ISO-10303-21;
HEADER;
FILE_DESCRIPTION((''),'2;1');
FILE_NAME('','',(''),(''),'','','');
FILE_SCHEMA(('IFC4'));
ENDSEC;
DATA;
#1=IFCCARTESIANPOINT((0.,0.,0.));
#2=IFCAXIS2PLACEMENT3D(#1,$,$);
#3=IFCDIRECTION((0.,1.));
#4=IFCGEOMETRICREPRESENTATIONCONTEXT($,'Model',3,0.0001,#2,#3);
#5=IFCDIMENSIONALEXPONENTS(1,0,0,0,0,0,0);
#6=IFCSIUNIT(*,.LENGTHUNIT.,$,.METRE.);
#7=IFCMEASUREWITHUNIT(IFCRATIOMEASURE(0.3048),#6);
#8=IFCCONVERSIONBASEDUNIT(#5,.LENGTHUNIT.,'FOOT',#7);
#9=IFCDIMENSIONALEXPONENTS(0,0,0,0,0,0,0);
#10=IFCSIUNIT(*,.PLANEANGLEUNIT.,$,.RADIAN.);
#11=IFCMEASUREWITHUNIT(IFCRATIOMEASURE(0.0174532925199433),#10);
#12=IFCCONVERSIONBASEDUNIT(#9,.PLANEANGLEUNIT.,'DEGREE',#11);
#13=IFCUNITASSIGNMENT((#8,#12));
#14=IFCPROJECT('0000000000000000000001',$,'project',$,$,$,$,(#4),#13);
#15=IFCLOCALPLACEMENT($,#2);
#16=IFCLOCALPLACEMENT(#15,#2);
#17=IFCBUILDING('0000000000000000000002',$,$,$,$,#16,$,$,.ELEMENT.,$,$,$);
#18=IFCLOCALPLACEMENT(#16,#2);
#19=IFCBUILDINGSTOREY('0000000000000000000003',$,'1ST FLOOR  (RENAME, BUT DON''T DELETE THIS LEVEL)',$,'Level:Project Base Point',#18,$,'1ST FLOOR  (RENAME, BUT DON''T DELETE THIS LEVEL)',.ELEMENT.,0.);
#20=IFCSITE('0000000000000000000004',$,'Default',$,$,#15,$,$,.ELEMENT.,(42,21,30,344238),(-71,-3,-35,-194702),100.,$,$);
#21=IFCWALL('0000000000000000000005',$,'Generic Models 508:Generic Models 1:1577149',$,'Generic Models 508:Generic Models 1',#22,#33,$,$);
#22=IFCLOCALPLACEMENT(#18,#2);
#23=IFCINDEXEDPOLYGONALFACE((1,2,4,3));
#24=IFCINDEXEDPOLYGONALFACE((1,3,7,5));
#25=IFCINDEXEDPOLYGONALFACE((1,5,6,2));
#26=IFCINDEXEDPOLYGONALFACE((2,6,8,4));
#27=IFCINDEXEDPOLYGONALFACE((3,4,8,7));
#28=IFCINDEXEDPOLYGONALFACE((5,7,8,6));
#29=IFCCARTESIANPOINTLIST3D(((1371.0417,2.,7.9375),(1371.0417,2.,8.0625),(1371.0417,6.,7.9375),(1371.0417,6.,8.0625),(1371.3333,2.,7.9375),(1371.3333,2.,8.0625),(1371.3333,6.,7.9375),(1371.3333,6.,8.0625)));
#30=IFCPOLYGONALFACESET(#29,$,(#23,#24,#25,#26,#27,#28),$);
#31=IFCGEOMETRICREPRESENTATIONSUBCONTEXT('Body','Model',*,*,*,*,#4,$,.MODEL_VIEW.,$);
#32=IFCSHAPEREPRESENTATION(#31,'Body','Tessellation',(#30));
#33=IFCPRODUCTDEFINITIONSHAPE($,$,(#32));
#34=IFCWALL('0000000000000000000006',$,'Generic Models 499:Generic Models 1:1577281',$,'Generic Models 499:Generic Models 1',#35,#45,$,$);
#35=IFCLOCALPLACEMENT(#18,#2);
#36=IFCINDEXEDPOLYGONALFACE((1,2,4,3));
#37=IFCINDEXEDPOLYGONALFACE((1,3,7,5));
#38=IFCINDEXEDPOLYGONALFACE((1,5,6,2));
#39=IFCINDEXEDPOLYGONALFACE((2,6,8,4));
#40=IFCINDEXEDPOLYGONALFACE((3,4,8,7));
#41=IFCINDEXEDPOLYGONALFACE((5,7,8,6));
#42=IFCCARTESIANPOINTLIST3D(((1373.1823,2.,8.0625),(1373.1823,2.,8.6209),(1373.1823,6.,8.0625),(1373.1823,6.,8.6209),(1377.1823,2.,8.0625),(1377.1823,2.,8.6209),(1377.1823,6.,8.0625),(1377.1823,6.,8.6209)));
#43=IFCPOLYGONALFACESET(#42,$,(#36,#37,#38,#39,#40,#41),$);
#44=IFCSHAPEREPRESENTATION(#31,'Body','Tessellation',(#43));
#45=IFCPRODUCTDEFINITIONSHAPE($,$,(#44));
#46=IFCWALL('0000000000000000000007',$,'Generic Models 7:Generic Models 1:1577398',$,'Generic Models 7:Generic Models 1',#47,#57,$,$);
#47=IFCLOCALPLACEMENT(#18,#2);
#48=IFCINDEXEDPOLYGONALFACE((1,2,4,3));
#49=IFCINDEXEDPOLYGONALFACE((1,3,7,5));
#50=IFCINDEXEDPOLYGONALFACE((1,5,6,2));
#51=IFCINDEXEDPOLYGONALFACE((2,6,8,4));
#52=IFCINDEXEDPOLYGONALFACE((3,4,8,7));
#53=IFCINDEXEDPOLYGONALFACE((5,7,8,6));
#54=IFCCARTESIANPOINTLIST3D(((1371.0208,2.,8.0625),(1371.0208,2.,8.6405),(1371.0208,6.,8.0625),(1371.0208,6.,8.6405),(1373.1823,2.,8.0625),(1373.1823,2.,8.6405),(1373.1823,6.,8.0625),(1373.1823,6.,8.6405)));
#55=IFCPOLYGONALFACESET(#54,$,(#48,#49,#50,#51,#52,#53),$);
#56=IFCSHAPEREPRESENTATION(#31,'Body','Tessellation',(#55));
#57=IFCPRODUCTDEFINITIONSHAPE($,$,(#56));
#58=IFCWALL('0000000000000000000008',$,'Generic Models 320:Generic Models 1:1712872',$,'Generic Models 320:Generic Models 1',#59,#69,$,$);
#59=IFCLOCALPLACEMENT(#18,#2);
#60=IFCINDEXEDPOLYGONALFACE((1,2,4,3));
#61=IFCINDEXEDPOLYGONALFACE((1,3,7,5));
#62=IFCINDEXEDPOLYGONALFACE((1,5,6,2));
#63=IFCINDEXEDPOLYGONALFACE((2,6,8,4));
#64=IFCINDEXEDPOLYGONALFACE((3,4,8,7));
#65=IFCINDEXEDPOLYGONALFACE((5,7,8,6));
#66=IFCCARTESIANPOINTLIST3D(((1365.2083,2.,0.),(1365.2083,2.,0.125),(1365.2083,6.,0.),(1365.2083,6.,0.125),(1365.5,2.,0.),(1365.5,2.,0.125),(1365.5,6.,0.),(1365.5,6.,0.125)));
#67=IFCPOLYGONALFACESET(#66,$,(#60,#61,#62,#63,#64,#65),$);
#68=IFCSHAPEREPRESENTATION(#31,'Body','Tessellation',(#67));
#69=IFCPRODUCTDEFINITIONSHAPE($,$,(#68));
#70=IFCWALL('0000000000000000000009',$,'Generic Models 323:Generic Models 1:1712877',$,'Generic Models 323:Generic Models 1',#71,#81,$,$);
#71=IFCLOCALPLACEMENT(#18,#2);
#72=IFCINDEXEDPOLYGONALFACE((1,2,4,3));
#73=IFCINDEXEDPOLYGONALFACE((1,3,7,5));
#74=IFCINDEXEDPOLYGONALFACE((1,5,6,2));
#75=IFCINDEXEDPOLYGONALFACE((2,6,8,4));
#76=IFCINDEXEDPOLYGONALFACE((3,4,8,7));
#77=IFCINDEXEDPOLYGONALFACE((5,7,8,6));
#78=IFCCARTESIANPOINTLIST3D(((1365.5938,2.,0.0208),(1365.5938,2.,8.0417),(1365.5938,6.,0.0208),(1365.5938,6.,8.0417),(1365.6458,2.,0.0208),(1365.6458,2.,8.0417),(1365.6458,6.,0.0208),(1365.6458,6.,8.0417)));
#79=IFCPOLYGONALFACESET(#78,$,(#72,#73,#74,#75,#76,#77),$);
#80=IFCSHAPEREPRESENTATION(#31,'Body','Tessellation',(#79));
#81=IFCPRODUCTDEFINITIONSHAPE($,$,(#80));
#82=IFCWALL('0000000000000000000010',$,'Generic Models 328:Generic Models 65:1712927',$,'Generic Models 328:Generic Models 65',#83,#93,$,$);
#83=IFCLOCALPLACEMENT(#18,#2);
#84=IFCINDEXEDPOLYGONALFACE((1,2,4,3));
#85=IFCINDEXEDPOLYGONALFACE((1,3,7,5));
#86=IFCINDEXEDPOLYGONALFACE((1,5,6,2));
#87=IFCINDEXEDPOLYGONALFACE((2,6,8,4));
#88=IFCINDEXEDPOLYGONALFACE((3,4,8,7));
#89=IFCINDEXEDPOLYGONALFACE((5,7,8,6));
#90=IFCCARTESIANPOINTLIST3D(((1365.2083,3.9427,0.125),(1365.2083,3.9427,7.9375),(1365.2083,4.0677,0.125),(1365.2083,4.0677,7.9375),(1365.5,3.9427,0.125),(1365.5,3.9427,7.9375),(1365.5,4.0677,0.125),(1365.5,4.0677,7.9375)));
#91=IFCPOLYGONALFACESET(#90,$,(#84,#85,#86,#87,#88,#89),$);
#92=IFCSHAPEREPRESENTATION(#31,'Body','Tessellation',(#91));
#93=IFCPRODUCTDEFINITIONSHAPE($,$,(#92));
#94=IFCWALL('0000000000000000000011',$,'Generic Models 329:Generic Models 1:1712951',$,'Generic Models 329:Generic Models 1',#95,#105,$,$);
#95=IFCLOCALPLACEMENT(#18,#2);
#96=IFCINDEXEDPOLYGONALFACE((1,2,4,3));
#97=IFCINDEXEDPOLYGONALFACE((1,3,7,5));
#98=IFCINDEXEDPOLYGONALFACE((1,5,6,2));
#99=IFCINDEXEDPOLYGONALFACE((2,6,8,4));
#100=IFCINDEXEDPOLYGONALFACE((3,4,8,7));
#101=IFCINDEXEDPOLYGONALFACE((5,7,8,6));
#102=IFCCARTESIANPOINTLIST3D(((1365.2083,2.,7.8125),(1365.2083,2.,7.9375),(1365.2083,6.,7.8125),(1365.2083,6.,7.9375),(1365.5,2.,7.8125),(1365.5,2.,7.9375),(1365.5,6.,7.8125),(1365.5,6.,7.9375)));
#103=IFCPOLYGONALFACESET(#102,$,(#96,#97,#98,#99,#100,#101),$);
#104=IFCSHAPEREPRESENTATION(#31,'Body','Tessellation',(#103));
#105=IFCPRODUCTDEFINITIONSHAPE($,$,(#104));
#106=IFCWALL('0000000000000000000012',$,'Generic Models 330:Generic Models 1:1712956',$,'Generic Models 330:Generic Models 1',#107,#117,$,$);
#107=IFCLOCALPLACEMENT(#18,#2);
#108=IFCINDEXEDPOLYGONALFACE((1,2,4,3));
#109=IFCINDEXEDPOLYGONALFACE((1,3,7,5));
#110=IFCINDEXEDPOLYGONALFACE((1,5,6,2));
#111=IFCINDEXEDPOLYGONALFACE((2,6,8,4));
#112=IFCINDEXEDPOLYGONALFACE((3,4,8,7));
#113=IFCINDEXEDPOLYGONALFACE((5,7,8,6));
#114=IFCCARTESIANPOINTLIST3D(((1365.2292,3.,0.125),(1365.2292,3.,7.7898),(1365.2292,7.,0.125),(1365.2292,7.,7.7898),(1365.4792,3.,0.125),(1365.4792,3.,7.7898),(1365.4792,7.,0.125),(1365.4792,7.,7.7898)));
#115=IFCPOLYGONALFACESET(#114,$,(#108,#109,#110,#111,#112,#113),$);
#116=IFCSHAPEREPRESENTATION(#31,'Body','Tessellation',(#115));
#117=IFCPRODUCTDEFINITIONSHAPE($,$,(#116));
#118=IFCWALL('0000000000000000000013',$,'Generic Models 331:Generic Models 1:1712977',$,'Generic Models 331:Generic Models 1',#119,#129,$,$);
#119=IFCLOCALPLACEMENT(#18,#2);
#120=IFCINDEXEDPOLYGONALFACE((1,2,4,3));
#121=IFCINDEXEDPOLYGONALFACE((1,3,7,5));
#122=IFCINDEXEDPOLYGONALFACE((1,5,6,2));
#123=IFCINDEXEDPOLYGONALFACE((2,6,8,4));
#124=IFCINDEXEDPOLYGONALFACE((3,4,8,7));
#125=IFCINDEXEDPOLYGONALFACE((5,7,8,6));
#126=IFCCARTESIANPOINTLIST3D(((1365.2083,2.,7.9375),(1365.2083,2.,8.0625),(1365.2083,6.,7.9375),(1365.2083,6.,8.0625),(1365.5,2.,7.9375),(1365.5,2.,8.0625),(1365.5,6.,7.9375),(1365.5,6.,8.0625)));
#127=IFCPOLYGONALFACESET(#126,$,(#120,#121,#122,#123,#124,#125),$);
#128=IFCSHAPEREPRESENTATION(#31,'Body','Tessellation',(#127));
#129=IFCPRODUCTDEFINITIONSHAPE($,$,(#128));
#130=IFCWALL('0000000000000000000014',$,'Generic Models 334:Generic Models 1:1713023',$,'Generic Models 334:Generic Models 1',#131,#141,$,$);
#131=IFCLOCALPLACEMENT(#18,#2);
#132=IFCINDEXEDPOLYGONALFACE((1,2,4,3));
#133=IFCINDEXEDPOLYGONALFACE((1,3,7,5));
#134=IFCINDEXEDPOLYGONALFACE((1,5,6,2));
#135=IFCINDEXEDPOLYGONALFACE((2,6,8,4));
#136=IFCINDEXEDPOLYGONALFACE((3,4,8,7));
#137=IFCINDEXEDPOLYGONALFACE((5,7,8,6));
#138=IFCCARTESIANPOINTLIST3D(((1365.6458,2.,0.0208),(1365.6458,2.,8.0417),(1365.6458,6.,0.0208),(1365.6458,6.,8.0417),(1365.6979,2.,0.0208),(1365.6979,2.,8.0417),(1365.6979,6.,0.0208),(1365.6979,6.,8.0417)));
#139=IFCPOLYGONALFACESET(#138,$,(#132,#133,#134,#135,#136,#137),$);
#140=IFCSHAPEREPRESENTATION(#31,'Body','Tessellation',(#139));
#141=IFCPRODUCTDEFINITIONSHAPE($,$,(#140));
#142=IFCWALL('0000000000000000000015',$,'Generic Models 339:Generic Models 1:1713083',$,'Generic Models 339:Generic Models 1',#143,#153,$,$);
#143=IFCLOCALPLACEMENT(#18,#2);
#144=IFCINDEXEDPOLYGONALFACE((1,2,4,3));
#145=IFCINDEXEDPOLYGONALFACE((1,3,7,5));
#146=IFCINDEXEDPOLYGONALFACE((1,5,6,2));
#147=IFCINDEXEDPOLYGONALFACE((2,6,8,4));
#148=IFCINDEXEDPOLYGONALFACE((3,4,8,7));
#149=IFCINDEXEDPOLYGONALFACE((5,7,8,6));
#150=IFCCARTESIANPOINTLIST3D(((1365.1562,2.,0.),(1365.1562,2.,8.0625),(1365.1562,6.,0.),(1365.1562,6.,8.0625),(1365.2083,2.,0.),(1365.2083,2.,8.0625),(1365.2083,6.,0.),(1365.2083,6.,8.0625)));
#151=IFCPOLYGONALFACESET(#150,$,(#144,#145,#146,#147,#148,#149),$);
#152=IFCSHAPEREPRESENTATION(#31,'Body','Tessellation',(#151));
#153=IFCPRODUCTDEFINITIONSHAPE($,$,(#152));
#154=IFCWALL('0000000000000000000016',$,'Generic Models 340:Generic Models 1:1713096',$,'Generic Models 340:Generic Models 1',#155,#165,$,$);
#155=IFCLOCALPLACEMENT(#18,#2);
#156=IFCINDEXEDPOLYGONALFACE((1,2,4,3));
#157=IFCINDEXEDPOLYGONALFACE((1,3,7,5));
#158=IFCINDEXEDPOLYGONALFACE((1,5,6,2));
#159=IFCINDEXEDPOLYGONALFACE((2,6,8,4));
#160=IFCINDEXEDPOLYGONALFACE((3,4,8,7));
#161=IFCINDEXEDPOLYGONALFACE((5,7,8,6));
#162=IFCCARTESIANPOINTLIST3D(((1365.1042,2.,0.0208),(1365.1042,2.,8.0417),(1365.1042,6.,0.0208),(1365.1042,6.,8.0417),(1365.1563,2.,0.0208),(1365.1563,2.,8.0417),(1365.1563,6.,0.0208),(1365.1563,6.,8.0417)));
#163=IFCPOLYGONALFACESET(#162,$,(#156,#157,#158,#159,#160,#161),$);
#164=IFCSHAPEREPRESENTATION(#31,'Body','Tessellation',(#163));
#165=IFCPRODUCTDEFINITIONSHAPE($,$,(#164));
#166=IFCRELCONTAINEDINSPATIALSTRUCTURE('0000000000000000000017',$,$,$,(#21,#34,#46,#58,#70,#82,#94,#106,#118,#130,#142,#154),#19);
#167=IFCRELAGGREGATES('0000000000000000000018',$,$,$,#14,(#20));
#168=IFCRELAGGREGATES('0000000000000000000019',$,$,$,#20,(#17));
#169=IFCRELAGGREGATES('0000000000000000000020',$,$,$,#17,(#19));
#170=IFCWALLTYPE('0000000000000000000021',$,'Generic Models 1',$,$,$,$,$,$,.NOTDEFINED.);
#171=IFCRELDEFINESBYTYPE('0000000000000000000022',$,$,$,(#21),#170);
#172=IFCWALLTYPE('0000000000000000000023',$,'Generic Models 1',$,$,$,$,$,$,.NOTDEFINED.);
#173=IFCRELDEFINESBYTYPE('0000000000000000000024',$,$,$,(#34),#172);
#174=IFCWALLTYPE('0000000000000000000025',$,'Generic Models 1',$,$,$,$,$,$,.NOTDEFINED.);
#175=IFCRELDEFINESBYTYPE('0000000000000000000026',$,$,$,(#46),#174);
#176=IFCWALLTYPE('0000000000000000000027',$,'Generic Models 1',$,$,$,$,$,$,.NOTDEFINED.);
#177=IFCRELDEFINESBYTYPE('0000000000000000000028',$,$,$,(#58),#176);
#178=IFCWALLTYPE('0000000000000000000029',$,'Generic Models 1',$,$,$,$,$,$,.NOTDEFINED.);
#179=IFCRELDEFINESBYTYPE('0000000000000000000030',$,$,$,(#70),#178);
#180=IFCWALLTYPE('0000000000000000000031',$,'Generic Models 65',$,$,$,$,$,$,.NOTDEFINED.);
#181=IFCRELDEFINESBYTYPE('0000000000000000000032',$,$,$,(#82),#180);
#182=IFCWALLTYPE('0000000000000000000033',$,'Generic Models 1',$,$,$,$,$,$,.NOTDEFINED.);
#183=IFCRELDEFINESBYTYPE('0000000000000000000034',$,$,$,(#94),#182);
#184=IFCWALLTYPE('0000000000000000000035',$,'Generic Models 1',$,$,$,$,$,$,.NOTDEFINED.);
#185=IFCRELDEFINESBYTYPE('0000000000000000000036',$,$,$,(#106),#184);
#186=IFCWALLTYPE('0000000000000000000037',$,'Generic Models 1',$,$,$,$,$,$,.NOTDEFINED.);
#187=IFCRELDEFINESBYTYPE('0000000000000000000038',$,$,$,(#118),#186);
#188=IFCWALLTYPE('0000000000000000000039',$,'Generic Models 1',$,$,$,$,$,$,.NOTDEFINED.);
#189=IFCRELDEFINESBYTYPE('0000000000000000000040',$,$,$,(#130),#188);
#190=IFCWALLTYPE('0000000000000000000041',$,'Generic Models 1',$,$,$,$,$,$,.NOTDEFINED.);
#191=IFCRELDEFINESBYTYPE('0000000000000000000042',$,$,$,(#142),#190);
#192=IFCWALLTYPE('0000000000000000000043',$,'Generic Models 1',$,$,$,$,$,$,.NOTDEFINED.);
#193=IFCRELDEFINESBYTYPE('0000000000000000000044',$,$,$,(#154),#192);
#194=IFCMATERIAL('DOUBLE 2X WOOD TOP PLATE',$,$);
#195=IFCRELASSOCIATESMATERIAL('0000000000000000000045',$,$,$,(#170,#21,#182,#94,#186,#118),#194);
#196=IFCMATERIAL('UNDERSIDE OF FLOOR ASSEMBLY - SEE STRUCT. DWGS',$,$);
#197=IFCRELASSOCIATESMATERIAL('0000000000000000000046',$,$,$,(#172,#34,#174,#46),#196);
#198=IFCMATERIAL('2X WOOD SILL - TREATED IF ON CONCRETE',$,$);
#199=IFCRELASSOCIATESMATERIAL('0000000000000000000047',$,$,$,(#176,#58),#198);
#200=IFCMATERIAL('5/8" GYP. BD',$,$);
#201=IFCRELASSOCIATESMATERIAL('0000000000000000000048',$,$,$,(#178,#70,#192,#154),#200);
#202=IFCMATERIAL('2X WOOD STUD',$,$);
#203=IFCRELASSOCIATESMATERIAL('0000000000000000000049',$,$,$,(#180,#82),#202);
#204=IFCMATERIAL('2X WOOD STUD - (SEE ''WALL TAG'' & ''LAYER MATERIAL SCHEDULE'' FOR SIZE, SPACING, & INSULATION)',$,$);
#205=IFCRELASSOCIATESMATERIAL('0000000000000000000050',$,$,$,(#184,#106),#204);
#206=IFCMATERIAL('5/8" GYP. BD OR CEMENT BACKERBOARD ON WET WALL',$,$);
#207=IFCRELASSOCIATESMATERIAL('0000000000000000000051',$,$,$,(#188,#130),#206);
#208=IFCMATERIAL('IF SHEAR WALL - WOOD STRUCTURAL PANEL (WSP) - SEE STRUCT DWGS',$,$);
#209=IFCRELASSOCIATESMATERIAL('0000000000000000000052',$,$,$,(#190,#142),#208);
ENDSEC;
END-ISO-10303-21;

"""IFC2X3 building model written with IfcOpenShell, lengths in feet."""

from ifc_helpers import new_model, entity, si_unit, converted_unit, direction, frame, frame_2d, origin, origin_2d_with_axis, place, context, subcontext, project, spatial, rectangle, extrude, material, type_object, element, save


model = new_model("IFC2X3")

# Units and contexts
model_context = context("Model", 3, precision=0.0001, world=origin(), true_north=direction((0.0, 1.0)))
body_context = subcontext(model_context, "Body", "Model", "MODEL_VIEW")
ifc_project = project(units=[converted_unit("LENGTHUNIT", "FOOT", entity("IfcRatioMeasure", 0.3048), si_unit("LENGTHUNIT", "METRE"), dimensions=[1, 0, 0, 0, 0, 0, 0]), converted_unit("PLANEANGLEUNIT", "DEGREE", entity("IfcRatioMeasure", 0.0174532925199433), si_unit("PLANEANGLEUNIT", "RADIAN"), dimensions=[0, 0, 0, 0, 0, 0, 0])], contexts=[model_context])

# Site, building, storey
site_placement = place(None, origin())
site = spatial("IfcSite", under=ifc_project, at=site_placement, Name="Default", CompositionType="ELEMENT", RefLatitude=(42, 21, 30, 344238), RefLongitude=(-71, -3, -35, -194702), RefElevation=100.0)
building_placement = place(site_placement, origin())
building = spatial("IfcBuilding", under=site, at=building_placement, CompositionType="ELEMENT")
storey_placement = place(building_placement, origin())
storey = spatial("IfcBuildingStorey", under=building, at=storey_placement, Name="1ST FLOOR  (RENAME, BUT DON'T DELETE THIS LEVEL)", ObjectType="Level:Project Base Point", LongName="1ST FLOOR  (RENAME, BUT DON'T DELETE THIS LEVEL)", CompositionType="ELEMENT", Elevation=0.0)

# Walls
ifc_material_1 = material(Name="2X WOOD SILL - TREATED IF ON CONCRETE")
ifc_material_2 = material(Name="5/8\" GYP. BD OR CEMENT BACKERBOARD ON WET WALL")
ifc_material_3 = material(Name="2X WOOD STUD")
ifc_material_4 = material(Name="DOUBLE 2X WOOD TOP PLATE")
ifc_material_5 = material(Name="2X WOOD STUD - (SEE 'WALL TAG' & 'LAYER MATERIAL SCHEDULE' FOR SIZE, SPACING, & INSULATION)")
wall_type_1 = type_object("IfcWallType", Name="Generic Models 1", PredefinedType="NOTDEFINED", material=ifc_material_4)
wall_1_placement = place(storey_placement, frame((1371.0417, 2.0, 7.9375), z_axis=(0.0, 0.0, 1.0), x_axis=(0.0, 1.0, 0.0)))
element("IfcWall", 1, at=wall_1_placement, inside=storey, type_object=wall_type_1, material=ifc_material_4, Name="Generic Models 508:Generic Models 1:1577149", ObjectType="Generic Models 508:Generic Models 1", context=body_context, shape_type="SweptSolid", body=[
    extrude(rectangle(XDim=4.0, YDim=0.2917, at=frame_2d((0.0, 0.0), x_axis=(1.0, 0.0))), frame((2.0, -0.1458, 0.0)), (0.0, 0.0, 1.0), 0.125),
])
ifc_material_6 = material(Name="UNDERSIDE OF FLOOR ASSEMBLY - SEE STRUCT. DWGS")
wall_type_2 = type_object("IfcWallType", Name="Generic Models 1", PredefinedType="NOTDEFINED", material=ifc_material_6)
wall_2_placement = place(storey_placement, frame((1373.1823, 2.0, 8.0625), z_axis=(0.0, 0.0, 1.0), x_axis=(0.0, 1.0, 0.0)))
element("IfcWall", 2, at=wall_2_placement, inside=storey, type_object=wall_type_2, material=ifc_material_6, Name="Generic Models 499:Generic Models 1:1577281", ObjectType="Generic Models 499:Generic Models 1", context=body_context, shape_type="SweptSolid", body=[
    extrude(rectangle(XDim=4.0, YDim=4.0, at=origin_2d_with_axis()), frame((2.0, -2.0, 0.0)), (0.0, 0.0, 1.0), 0.5584),
])
wall_type_3 = type_object("IfcWallType", Name="Generic Models 1", PredefinedType="NOTDEFINED", material=ifc_material_6)
wall_3_placement = place(storey_placement, frame((1371.0208, 2.0, 8.0625), z_axis=(0.0, 0.0, 1.0), x_axis=(0.0, 1.0, 0.0)))
element("IfcWall", 3, at=wall_3_placement, inside=storey, type_object=wall_type_3, material=ifc_material_6, Name="Generic Models 7:Generic Models 1:1577398", ObjectType="Generic Models 7:Generic Models 1", context=body_context, shape_type="SweptSolid", body=[
    extrude(rectangle(XDim=4.0, YDim=2.1615, at=frame_2d((0.0, 0.0), x_axis=(1.0, 0.0))), frame((2.0, -1.0807, 0.0)), (0.0, 0.0, 1.0), 0.578),
])
wall_type_4 = type_object("IfcWallType", Name="Generic Models 1", PredefinedType="NOTDEFINED", material=ifc_material_1)
wall_4_placement = place(storey_placement, frame((1365.2083, 2.0, 0.0), z_axis=(0.0, 0.0, 1.0), x_axis=(0.0, 1.0, 0.0)))
element("IfcWall", 4, at=wall_4_placement, inside=storey, type_object=wall_type_4, material=ifc_material_1, Name="Generic Models 320:Generic Models 1:1712872", ObjectType="Generic Models 320:Generic Models 1", context=body_context, shape_type="SweptSolid", body=[
    extrude(rectangle(XDim=4.0, YDim=0.2917, at=frame_2d((0.0, 0.0), x_axis=(1.0, 0.0))), frame((2.0, -0.1458, 0.0)), (0.0, 0.0, 1.0), 0.125),
])
ifc_material_7 = material(Name="5/8\" GYP. BD")
wall_type_5 = type_object("IfcWallType", Name="Generic Models 1", PredefinedType="NOTDEFINED", material=ifc_material_7)
wall_5_placement = place(storey_placement, frame((1365.5938, 2.0, 0.0208), z_axis=(0.0, 0.0, 1.0), x_axis=(0.0, 1.0, 0.0)))
element("IfcWall", 5, at=wall_5_placement, inside=storey, type_object=wall_type_5, material=ifc_material_7, Name="Generic Models 323:Generic Models 1:1712877", ObjectType="Generic Models 323:Generic Models 1", context=body_context, shape_type="SweptSolid", body=[
    extrude(rectangle(XDim=4.0, YDim=0.0521, at=origin_2d_with_axis()), frame((2.0, -0.026, 0.0)), (0.0, 0.0, 1.0), 8.0208),
])
wall_type_6 = type_object("IfcWallType", Name="Generic Models 65", PredefinedType="NOTDEFINED", material=ifc_material_3)
wall_6_placement = place(storey_placement, frame((1365.2083, 3.9427, 0.125)))
element("IfcWall", 6, at=wall_6_placement, inside=storey, type_object=wall_type_6, material=ifc_material_3, Name="Generic Models 328:Generic Models 65:1712927", ObjectType="Generic Models 328:Generic Models 65", context=body_context, shape_type="SweptSolid", body=[
    extrude(rectangle(XDim=0.125, YDim=0.2917, at=frame_2d((0.0, 0.0), x_axis=(1.0, 0.0))), frame((0.1458, 0.0625, 0.0), z_axis=(0.0, 0.0, 1.0), x_axis=(0.0, 1.0, 0.0)), (0.0, 0.0, 1.0), 7.8125),
])
wall_type_7 = type_object("IfcWallType", Name="Generic Models 1", PredefinedType="NOTDEFINED", material=ifc_material_4)
wall_7_placement = place(storey_placement, frame((1365.2083, 2.0, 7.8125), z_axis=(0.0, 0.0, 1.0), x_axis=(0.0, 1.0, 0.0)))
element("IfcWall", 7, at=wall_7_placement, inside=storey, type_object=wall_type_7, material=ifc_material_4, Name="Generic Models 329:Generic Models 1:1712951", ObjectType="Generic Models 329:Generic Models 1", context=body_context, shape_type="SweptSolid", body=[
    extrude(rectangle(XDim=4.0, YDim=0.2917, at=frame_2d((0.0, 0.0), x_axis=(1.0, 0.0))), frame((2.0, -0.1458, 0.0)), (0.0, 0.0, 1.0), 0.125),
])
wall_type_8 = type_object("IfcWallType", Name="Generic Models 1", PredefinedType="NOTDEFINED", material=ifc_material_5)
wall_8_placement = place(storey_placement, frame((1365.2292, 3.0, 0.125), z_axis=(0.0, 0.0, 1.0), x_axis=(0.0, 1.0, 0.0)))
element("IfcWall", 8, at=wall_8_placement, inside=storey, type_object=wall_type_8, material=ifc_material_5, Name="Generic Models 330:Generic Models 1:1712956", ObjectType="Generic Models 330:Generic Models 1", context=body_context, shape_type="SweptSolid", body=[
    extrude(rectangle(XDim=4.0, YDim=0.25, at=frame_2d((0.0, 0.0), x_axis=(1.0, 0.0))), frame((2.0, -0.125, 0.0)), (0.0, 0.0, 1.0), 7.6648),
])
wall_type_9 = type_object("IfcWallType", Name="Generic Models 1", PredefinedType="NOTDEFINED", material=ifc_material_4)
wall_9_placement = place(storey_placement, frame((1365.2083, 2.0, 7.9375), z_axis=(0.0, 0.0, 1.0), x_axis=(0.0, 1.0, 0.0)))
element("IfcWall", 9, at=wall_9_placement, inside=storey, type_object=wall_type_9, material=ifc_material_4, Name="Generic Models 331:Generic Models 1:1712977", ObjectType="Generic Models 331:Generic Models 1", context=body_context, shape_type="SweptSolid", body=[
    extrude(rectangle(XDim=4.0, YDim=0.2917, at=frame_2d((0.0, 0.0), x_axis=(1.0, 0.0))), frame((2.0, -0.1458, 0.0)), (0.0, 0.0, 1.0), 0.125),
])
wall_type_10 = type_object("IfcWallType", Name="Generic Models 1", PredefinedType="NOTDEFINED", material=ifc_material_2)
wall_10_placement = place(storey_placement, frame((1365.6458, 2.0, 0.0208), z_axis=(0.0, 0.0, 1.0), x_axis=(0.0, 1.0, 0.0)))
element("IfcWall", 10, at=wall_10_placement, inside=storey, type_object=wall_type_10, material=ifc_material_2, Name="Generic Models 334:Generic Models 1:1713023", ObjectType="Generic Models 334:Generic Models 1", context=body_context, shape_type="SweptSolid", body=[
    extrude(rectangle(XDim=4.0, YDim=0.0521, at=frame_2d((0.0, 0.0), x_axis=(1.0, 0.0))), frame((2.0, -0.026, 0.0)), (0.0, 0.0, 1.0), 8.0208),
])
ifc_material_8 = material(Name="IF SHEAR WALL - WOOD STRUCTURAL PANEL (WSP) - SEE STRUCT DWGS")
wall_type_11 = type_object("IfcWallType", Name="Generic Models 1", PredefinedType="NOTDEFINED", material=ifc_material_8)
wall_11_placement = place(storey_placement, frame((1365.1562, 2.0, 0.0), z_axis=(0.0, 0.0, 1.0), x_axis=(0.0, 1.0, 0.0)))
element("IfcWall", 11, at=wall_11_placement, inside=storey, type_object=wall_type_11, material=ifc_material_8, Name="Generic Models 339:Generic Models 1:1713083", ObjectType="Generic Models 339:Generic Models 1", context=body_context, shape_type="SweptSolid", body=[
    extrude(rectangle(XDim=4.0, YDim=0.0521, at=origin_2d_with_axis()), frame((2.0, -0.026, 0.0)), (0.0, 0.0, 1.0), 8.0625),
])
wall_type_12 = type_object("IfcWallType", Name="Generic Models 1", PredefinedType="NOTDEFINED", material=ifc_material_7)
wall_12_placement = place(storey_placement, frame((1365.1042, 2.0, 0.0208), z_axis=(0.0, 0.0, 1.0), x_axis=(0.0, 1.0, 0.0)))
element("IfcWall", 12, at=wall_12_placement, inside=storey, type_object=wall_type_12, material=ifc_material_7, Name="Generic Models 340:Generic Models 1:1713096", ObjectType="Generic Models 340:Generic Models 1", context=body_context, shape_type="SweptSolid", body=[
    extrude(rectangle(XDim=4.0, YDim=0.0521, at=frame_2d((0.0, 0.0), x_axis=(1.0, 0.0))), frame((2.0, -0.026, 0.0)), (0.0, 0.0, 1.0), 8.0208),
])

save(model, "model.ifc")
